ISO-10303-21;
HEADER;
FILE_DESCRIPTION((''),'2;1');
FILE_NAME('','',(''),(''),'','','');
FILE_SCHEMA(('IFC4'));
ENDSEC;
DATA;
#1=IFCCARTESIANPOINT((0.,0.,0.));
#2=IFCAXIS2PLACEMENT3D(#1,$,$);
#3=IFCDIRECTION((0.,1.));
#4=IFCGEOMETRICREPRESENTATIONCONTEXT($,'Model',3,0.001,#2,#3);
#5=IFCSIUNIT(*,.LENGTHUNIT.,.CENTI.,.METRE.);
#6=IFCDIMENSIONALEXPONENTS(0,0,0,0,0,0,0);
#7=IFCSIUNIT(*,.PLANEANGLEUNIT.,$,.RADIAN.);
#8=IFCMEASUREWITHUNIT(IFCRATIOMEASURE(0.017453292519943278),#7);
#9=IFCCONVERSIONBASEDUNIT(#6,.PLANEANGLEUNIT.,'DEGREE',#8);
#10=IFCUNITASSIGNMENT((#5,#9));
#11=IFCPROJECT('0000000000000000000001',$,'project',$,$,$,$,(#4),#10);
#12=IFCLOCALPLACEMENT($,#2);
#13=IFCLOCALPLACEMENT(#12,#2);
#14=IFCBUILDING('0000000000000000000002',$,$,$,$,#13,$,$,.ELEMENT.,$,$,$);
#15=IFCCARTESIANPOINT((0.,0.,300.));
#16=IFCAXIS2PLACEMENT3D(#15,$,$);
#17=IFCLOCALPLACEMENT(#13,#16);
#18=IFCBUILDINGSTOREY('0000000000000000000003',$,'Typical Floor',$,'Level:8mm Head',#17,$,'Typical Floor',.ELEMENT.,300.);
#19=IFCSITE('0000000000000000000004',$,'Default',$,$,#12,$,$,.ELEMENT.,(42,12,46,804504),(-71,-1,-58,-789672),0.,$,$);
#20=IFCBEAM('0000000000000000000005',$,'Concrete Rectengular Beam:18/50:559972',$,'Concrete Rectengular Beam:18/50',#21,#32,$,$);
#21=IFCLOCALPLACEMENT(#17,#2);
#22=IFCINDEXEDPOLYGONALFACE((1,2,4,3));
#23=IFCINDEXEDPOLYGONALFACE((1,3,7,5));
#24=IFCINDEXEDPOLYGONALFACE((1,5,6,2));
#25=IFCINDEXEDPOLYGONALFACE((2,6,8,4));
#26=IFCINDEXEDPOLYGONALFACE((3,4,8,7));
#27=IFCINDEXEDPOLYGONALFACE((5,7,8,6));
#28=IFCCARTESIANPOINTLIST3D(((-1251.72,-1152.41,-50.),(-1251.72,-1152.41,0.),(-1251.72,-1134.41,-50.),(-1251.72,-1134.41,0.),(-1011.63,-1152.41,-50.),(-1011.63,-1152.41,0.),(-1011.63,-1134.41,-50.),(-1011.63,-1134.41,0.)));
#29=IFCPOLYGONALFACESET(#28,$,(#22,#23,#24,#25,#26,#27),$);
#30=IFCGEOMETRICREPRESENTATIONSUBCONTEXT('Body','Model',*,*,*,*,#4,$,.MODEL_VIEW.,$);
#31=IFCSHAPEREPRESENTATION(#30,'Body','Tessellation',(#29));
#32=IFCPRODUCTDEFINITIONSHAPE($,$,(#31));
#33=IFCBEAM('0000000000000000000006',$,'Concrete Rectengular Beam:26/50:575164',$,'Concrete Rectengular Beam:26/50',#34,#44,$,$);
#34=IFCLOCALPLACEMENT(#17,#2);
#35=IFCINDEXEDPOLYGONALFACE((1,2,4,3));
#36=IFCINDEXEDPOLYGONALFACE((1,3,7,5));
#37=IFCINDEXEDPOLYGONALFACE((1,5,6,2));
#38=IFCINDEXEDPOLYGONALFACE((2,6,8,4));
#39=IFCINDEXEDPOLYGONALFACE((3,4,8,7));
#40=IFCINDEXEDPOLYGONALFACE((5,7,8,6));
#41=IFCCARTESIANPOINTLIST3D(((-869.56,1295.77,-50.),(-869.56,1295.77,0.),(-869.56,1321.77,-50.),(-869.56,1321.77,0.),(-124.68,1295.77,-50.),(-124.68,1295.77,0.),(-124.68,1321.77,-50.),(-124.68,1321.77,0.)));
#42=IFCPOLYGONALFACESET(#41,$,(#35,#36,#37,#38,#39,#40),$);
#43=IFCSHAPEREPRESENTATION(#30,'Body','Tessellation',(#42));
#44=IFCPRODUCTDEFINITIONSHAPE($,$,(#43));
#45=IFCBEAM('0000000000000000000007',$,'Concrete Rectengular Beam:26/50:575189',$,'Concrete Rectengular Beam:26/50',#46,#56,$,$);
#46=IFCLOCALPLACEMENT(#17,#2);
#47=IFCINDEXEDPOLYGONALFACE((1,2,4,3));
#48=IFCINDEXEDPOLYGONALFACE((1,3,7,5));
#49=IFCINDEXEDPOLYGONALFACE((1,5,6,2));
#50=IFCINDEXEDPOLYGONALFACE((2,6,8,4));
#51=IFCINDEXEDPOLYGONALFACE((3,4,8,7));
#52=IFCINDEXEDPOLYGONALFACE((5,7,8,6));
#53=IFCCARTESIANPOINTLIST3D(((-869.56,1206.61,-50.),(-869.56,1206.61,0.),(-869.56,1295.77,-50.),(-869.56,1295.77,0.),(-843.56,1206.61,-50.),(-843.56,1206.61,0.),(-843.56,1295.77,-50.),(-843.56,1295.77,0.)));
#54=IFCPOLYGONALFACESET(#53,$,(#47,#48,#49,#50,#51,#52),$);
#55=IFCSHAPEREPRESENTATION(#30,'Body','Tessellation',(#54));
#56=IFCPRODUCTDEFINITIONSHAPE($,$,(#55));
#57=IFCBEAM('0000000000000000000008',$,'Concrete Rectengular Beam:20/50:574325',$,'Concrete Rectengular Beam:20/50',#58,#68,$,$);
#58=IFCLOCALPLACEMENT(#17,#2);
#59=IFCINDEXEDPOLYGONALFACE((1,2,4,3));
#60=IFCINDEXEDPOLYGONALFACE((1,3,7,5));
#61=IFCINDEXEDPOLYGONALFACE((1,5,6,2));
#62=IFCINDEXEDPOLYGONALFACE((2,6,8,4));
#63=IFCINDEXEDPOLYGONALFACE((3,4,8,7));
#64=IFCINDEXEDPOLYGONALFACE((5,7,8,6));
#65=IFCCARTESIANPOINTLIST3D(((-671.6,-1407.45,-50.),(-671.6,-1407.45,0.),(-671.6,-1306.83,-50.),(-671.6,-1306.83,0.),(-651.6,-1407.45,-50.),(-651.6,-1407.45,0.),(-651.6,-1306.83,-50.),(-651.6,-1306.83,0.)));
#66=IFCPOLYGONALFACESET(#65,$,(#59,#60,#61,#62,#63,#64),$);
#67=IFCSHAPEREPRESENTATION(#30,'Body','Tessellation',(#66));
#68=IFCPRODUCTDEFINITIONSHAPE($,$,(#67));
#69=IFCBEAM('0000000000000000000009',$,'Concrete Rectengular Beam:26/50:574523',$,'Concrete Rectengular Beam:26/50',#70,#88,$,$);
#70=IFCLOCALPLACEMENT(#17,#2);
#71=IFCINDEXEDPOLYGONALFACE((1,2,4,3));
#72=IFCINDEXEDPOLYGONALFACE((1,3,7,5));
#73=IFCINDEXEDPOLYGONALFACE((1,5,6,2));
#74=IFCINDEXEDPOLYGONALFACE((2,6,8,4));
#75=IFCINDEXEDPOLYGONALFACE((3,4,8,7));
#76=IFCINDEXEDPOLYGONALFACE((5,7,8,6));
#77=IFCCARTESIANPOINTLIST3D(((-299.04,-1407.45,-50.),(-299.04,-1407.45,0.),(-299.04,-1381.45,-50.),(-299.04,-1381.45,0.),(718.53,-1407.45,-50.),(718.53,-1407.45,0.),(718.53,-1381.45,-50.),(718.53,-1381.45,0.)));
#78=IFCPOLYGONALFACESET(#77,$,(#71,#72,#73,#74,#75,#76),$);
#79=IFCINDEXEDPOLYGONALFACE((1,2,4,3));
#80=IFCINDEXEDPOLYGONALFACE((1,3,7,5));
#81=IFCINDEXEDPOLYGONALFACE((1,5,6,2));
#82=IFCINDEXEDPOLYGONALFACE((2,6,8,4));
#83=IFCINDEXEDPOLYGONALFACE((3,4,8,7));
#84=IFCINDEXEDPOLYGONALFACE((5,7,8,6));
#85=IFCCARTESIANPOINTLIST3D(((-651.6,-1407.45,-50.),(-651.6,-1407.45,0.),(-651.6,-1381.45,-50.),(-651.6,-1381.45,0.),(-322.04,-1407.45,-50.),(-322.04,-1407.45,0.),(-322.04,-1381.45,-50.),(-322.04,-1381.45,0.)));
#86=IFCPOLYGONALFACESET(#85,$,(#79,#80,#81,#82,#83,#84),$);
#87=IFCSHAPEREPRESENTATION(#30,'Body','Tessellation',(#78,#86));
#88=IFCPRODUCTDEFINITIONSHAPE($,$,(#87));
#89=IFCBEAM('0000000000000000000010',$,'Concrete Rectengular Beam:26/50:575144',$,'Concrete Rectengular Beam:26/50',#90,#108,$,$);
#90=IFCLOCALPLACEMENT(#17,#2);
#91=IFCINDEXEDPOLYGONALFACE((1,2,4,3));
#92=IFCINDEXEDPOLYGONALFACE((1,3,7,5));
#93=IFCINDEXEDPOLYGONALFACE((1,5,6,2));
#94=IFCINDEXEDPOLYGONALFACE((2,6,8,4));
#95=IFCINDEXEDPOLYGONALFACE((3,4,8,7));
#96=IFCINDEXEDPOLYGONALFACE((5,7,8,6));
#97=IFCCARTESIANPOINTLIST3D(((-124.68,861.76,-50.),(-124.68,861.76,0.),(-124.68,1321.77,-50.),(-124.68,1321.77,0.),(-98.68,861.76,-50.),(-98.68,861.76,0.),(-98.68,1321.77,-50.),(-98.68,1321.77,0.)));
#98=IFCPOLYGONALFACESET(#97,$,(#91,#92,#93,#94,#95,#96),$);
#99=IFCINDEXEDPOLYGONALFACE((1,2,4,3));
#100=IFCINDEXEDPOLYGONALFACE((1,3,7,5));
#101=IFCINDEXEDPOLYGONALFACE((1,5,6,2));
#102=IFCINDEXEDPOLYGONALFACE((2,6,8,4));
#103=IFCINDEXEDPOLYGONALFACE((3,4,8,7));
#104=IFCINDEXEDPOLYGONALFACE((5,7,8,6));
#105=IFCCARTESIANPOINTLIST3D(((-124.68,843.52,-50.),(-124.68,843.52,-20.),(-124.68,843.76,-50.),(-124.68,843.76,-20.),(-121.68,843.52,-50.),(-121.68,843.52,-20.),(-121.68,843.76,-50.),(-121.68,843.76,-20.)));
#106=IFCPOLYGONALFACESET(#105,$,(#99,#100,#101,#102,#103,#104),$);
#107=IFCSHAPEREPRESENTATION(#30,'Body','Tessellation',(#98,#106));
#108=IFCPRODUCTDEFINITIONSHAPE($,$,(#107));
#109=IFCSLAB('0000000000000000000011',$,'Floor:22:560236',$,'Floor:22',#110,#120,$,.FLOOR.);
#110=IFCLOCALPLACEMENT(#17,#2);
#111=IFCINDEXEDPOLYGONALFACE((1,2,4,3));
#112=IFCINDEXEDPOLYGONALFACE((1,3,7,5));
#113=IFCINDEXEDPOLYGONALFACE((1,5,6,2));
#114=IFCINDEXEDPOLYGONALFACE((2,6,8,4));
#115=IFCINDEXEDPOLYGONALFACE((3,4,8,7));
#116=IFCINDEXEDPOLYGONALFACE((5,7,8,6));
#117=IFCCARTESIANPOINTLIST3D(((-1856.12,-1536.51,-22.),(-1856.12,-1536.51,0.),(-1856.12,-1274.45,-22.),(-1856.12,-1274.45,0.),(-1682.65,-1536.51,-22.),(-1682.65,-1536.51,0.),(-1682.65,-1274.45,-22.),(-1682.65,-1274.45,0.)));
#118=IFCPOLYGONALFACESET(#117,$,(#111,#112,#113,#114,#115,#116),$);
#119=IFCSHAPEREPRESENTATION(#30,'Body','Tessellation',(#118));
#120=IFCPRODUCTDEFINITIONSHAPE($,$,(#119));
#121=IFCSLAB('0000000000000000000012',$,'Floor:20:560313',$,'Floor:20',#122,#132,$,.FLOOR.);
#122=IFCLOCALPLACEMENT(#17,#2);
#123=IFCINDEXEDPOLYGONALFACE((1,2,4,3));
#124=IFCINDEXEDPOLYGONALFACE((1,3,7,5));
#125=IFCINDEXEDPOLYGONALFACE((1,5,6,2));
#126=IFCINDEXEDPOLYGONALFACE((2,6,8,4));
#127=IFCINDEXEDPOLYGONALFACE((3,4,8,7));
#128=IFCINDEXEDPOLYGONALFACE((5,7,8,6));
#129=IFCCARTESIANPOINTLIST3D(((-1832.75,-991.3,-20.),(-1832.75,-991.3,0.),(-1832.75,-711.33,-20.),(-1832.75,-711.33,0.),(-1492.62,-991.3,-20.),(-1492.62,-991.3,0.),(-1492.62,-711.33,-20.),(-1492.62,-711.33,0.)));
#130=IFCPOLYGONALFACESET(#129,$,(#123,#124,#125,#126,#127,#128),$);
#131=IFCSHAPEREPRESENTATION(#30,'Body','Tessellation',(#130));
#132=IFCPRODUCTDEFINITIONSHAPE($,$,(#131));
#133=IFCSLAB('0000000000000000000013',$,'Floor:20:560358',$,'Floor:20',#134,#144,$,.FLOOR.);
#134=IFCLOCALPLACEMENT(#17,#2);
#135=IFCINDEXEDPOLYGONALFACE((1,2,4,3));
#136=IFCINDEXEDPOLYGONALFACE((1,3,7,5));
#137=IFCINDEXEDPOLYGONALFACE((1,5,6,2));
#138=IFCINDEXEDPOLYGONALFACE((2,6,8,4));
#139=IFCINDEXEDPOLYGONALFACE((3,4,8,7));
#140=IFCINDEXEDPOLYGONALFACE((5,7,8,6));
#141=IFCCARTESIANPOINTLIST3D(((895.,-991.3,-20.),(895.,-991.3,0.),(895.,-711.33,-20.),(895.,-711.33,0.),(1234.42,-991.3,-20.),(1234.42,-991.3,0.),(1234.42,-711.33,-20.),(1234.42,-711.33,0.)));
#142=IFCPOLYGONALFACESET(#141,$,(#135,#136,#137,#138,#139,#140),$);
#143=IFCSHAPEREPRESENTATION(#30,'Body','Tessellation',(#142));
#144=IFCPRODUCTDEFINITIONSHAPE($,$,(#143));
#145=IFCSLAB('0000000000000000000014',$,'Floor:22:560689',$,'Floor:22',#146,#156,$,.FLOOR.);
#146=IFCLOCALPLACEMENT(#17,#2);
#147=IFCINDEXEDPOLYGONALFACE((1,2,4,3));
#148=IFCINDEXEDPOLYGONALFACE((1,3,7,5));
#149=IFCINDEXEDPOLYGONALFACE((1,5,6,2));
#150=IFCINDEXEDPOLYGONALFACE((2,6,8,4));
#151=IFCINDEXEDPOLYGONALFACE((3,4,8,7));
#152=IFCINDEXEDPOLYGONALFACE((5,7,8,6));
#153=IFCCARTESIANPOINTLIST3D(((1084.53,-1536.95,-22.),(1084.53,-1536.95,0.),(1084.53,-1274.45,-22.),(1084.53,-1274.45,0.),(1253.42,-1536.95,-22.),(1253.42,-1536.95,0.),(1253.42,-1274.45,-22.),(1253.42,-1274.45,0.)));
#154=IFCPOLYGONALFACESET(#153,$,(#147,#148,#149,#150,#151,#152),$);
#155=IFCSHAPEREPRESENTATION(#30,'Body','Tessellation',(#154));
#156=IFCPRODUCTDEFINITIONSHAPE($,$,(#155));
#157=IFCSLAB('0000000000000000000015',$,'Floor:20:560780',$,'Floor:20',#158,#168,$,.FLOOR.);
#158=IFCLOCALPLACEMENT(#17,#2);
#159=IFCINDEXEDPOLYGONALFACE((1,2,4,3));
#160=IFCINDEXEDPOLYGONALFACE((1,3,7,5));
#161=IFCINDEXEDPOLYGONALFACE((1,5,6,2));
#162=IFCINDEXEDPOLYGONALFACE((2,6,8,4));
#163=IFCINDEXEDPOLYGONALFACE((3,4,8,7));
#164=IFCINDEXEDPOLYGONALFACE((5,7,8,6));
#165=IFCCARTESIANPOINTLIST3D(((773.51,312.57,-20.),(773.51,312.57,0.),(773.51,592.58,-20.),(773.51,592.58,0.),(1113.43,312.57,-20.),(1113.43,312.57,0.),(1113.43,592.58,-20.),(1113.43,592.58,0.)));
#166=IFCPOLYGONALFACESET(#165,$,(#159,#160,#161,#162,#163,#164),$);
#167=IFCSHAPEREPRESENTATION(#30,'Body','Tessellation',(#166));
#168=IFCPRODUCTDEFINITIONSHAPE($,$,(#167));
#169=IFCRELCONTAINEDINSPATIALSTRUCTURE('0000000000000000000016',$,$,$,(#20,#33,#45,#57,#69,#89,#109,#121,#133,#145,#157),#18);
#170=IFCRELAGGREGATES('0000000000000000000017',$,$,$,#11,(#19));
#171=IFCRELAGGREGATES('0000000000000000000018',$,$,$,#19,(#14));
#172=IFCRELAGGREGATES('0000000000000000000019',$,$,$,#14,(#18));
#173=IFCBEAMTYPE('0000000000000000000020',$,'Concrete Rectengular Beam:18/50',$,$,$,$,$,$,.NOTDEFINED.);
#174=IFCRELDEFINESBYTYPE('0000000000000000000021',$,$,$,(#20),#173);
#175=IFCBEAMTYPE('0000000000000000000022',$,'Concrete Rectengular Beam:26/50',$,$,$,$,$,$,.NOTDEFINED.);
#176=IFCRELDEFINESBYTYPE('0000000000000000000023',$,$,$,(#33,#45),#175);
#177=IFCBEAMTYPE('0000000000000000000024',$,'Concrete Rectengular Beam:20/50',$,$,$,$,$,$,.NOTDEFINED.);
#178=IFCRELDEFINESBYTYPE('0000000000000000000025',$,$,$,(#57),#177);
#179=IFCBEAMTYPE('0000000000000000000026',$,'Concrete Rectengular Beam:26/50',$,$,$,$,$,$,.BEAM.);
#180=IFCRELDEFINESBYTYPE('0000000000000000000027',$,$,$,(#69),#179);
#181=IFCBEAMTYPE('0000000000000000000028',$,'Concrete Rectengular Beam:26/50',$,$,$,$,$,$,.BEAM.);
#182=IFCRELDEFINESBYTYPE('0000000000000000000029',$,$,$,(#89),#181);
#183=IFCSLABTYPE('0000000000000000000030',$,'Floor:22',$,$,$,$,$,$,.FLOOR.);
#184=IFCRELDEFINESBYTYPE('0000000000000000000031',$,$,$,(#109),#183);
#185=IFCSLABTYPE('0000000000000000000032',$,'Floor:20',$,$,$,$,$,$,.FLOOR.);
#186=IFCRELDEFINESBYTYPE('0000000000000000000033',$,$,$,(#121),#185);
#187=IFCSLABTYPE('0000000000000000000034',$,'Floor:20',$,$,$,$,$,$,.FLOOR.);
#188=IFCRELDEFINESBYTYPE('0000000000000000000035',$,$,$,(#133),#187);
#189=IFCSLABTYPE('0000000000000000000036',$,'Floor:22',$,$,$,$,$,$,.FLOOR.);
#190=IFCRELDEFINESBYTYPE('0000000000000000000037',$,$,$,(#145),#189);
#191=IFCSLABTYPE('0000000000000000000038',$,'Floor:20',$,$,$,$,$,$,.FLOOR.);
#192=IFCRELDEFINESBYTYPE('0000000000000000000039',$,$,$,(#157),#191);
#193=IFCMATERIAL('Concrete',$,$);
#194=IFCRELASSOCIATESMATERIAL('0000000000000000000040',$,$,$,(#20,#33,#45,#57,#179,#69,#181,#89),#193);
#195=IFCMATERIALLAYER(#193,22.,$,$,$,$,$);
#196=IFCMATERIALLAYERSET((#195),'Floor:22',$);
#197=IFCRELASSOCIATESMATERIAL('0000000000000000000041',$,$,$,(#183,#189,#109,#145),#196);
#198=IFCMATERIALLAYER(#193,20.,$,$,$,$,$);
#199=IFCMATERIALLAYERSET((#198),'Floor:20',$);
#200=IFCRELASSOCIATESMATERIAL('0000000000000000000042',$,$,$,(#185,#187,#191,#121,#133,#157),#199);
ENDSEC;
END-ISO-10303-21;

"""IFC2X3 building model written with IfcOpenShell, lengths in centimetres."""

from ifc_helpers import new_model, entity, si_unit, converted_unit, direction, frame, frame_2d, origin, origin_2d_with_axis, place, context, subcontext, project, spatial, rectangle, extrude, source, transform, mapped, material, layer, layer_set, layer_usage, type_object, type_shapes, element, save


model = new_model("IFC2X3")

# Units and contexts
model_context = context("Model", 3, precision=0.001, world=origin(), true_north=direction((0.0, 1.0)))
body_context = subcontext(model_context, "Body", "Model", "MODEL_VIEW")
ifc_project = project(units=[si_unit("LENGTHUNIT", "METRE", prefix="CENTI"), converted_unit("PLANEANGLEUNIT", "DEGREE", entity("IfcRatioMeasure", 0.017453292519943278), si_unit("PLANEANGLEUNIT", "RADIAN"), dimensions=[0, 0, 0, 0, 0, 0, 0])], contexts=[model_context])

# Site, building, storey
site_placement = place(None, origin())
site = spatial("IfcSite", under=ifc_project, at=site_placement, Name="Default", CompositionType="ELEMENT", RefLatitude=(42, 12, 46, 804504), RefLongitude=(-71, -1, -58, -789672), RefElevation=0.0)
building_placement = place(site_placement, origin())
building = spatial("IfcBuilding", under=site, at=building_placement, CompositionType="ELEMENT")
storey_placement = place(building_placement, frame((0.0, 0.0, 300.0)))
storey = spatial("IfcBuildingStorey", under=building, at=storey_placement, Name="Typical Floor", ObjectType="Level:8mm Head", LongName="Typical Floor", CompositionType="ELEMENT", Elevation=300.0)

# Beams
ifc_material = material(Name="Concrete")
beam_type_1 = type_object("IfcBeamType", Name="Concrete Rectengular Beam:18/50", PredefinedType="NOTDEFINED")
beam_1_placement = place(storey_placement, frame((-1251.72, -1143.41, 0.0)))
element("IfcBeam", 1, at=beam_1_placement, inside=storey, type_object=beam_type_1, material=ifc_material, Name="Concrete Rectengular Beam:18/50:559972", ObjectType="Concrete Rectengular Beam:18/50", context=body_context, shape_type="SweptSolid", body=[
    extrude(rectangle(XDim=50.0, YDim=18.0, at=frame_2d((0.0, 0.0), x_axis=(1.0, 0.0))), frame((0.0, 0.0, -25.0), z_axis=(1.0, 0.0, 0.0), x_axis=(0.0, 0.0, -1.0)), (0.0, 0.0, 1.0), 240.09),
])
beam_type_2 = type_object("IfcBeamType", Name="Concrete Rectengular Beam:26/50", PredefinedType="NOTDEFINED")
beam_2_placement = place(storey_placement, frame((-111.68, 1308.77, 0.0), z_axis=(0.0, 0.0, 1.0), x_axis=(-1.0, 0.0, 0.0)))
element("IfcBeam", 2, at=beam_2_placement, inside=storey, type_object=beam_type_2, material=ifc_material, Name="Concrete Rectengular Beam:26/50:575164", ObjectType="Concrete Rectengular Beam:26/50", context=body_context, shape_type="SweptSolid", body=[
    extrude(rectangle(XDim=50.0, YDim=26.0, at=frame_2d((0.0, 0.0), x_axis=(1.0, 0.0))), frame((13.0, 0.0, -25.0), z_axis=(1.0, 0.0, 0.0), x_axis=(0.0, 0.0, -1.0)), (0.0, 0.0, 1.0), 744.88),
])
beam_3_placement = place(storey_placement, frame((-856.56, 1308.77, 0.0), z_axis=(0.0, 0.0, 1.0), x_axis=(0.0, -1.0, 0.0)))
element("IfcBeam", 3, at=beam_3_placement, inside=storey, type_object=beam_type_2, material=ifc_material, Name="Concrete Rectengular Beam:26/50:575189", ObjectType="Concrete Rectengular Beam:26/50", context=body_context, shape_type="SweptSolid", body=[
    extrude(rectangle(XDim=50.0, YDim=26.0, at=frame_2d((0.0, 0.0), x_axis=(1.0, 0.0))), frame((13.0, 0.0, -25.0), z_axis=(1.0, 0.0, 0.0), x_axis=(0.0, 0.0, -1.0)), (0.0, 0.0, 1.0), 89.16),
])
beam_type_3 = type_object("IfcBeamType", Name="Concrete Rectengular Beam:20/50", PredefinedType="NOTDEFINED")
beam_4_placement = place(storey_placement, frame((-661.6, -1306.83, 0.0), z_axis=(0.0, 0.0, 1.0), x_axis=(0.0, -1.0, 0.0)))
element("IfcBeam", 4, at=beam_4_placement, inside=storey, type_object=beam_type_3, material=ifc_material, Name="Concrete Rectengular Beam:20/50:574325", ObjectType="Concrete Rectengular Beam:20/50", context=body_context, shape_type="SweptSolid", body=[
    extrude(rectangle(XDim=50.0, YDim=20.0, at=frame_2d((0.0, 0.0), x_axis=(1.0, 0.0))), frame((0.0, 0.0, -25.0), z_axis=(1.0, 0.0, 0.0), x_axis=(0.0, 0.0, -1.0)), (0.0, 0.0, 1.0), 100.62),
])
beam_type_4 = type_object("IfcBeamType", Name="Concrete Rectengular Beam:26/50", PredefinedType="BEAM", material=ifc_material)
shared_shape_1 = source(origin(), body_context, "Body", "SweptSolid", [
    extrude(rectangle(XDim=50.0, YDim=26.0, at=frame_2d((0.0, 0.0), x_axis=(1.0, 0.0))), frame((-299.04, -1394.45, 275.0), z_axis=(1.0, 0.0, 0.0), x_axis=(0.0, 0.0, -1.0)), (0.0, 0.0, 1.0), 1017.58),
    extrude(rectangle(XDim=50.0, YDim=26.0, at=frame_2d((0.0, 0.0), x_axis=(1.0, 0.0))), frame((-651.6, -1394.45, 275.0), z_axis=(1.0, 0.0, 0.0), x_axis=(0.0, 0.0, -1.0)), (0.0, 0.0, 1.0), 329.56),
])
type_shapes(beam_type_4, [shared_shape_1])
beam_5_placement = place(storey_placement, frame((0.0, 0.0, -300.0)))
element("IfcBeam", 5, at=beam_5_placement, inside=storey, type_object=beam_type_4, material=ifc_material, Name="Concrete Rectengular Beam:26/50:574523", ObjectType="Concrete Rectengular Beam:26/50", context=body_context, shape_type="MappedRepresentation", body=[
    mapped(shared_shape_1, transform((0.0, 0.0, 0.0), scale=1.0)),
])
beam_type_5 = type_object("IfcBeamType", Name="Concrete Rectengular Beam:26/50", PredefinedType="BEAM", material=ifc_material)
shared_shape_2 = source(origin(), body_context, "Body", "SweptSolid", [
    extrude(rectangle(XDim=50.0, YDim=26.0, at=frame_2d((0.0, 0.0), x_axis=(0.0, 1.0))), frame((-111.68, 861.76, 275.0), z_axis=(0.0, 1.0, 0.0), x_axis=(-1.0, 0.0, 0.0)), (0.0, 0.0, 1.0), 460.01),
    extrude(rectangle(XDim=30.0, YDim=3.0, at=frame_2d((0.0, 0.0), x_axis=(0.0, 1.0))), frame((-123.18, 843.52, 265.0), z_axis=(0.0, 1.0, 0.0), x_axis=(-1.0, 0.0, 0.0)), (0.0, 0.0, 1.0), 0.24),
])
type_shapes(beam_type_5, [shared_shape_2])
beam_6_placement = place(storey_placement, frame((0.0, 0.0, -300.0)))
element("IfcBeam", 6, at=beam_6_placement, inside=storey, type_object=beam_type_5, material=ifc_material, Name="Concrete Rectengular Beam:26/50:575144", ObjectType="Concrete Rectengular Beam:26/50", context=body_context, shape_type="MappedRepresentation", body=[
    mapped(shared_shape_2, transform((0.0, 0.0, 0.0), scale=1.0)),
])

# Slabs
ifc_layer_1 = layer(ifc_material, 22.0)
ifc_layer_set_1 = layer_set([ifc_layer_1], Name="Floor:22")
ifc_layer_usage_1 = layer_usage(ifc_layer_set_1, "AXIS3", "POSITIVE", 0.0)
slab_type_1 = type_object("IfcSlabType", Name="Floor:22", PredefinedType="FLOOR", material=ifc_layer_set_1)
slab_1_placement = place(storey_placement, origin())
element("IfcSlab", 7, at=slab_1_placement, inside=storey, type_object=slab_type_1, material=ifc_layer_usage_1, Name="Floor:22:560236", ObjectType="Floor:22", PredefinedType="FLOOR", context=body_context, shape_type="SweptSolid", body=[
    extrude(rectangle(XDim=262.05, YDim=173.47, at=frame_2d((0.0, 0.0), x_axis=(1.0, 0.0))), frame((-1769.39, -1405.48, 0.0), z_axis=(0.0, 0.0, -1.0), x_axis=(0.0, 1.0, 0.0)), (0.0, 0.0, 1.0), 22.0),
])
ifc_layer_2 = layer(ifc_material, 20.0)
ifc_layer_set_2 = layer_set([ifc_layer_2], Name="Floor:20")
ifc_layer_usage_2 = layer_usage(ifc_layer_set_2, "AXIS3", "POSITIVE", 0.0)
slab_type_2 = type_object("IfcSlabType", Name="Floor:20", PredefinedType="FLOOR", material=ifc_layer_set_2)
slab_2_placement = place(storey_placement, origin())
element("IfcSlab", 8, at=slab_2_placement, inside=storey, type_object=slab_type_2, material=ifc_layer_usage_2, Name="Floor:20:560313", ObjectType="Floor:20", PredefinedType="FLOOR", context=body_context, shape_type="SweptSolid", body=[
    extrude(rectangle(XDim=279.98, YDim=340.13, at=frame_2d((0.0, 0.0), x_axis=(1.0, 0.0))), frame((-1662.69, -851.32, 0.0), z_axis=(0.0, 0.0, -1.0), x_axis=(0.0, 1.0, 0.0)), (0.0, 0.0, 1.0), 20.0),
])
ifc_layer_usage_3 = layer_usage(ifc_layer_set_2, "AXIS3", "POSITIVE", 0.0)
slab_type_3 = type_object("IfcSlabType", Name="Floor:20", PredefinedType="FLOOR", material=ifc_layer_set_2)
slab_3_placement = place(storey_placement, origin())
element("IfcSlab", 9, at=slab_3_placement, inside=storey, type_object=slab_type_3, material=ifc_layer_usage_3, Name="Floor:20:560358", ObjectType="Floor:20", PredefinedType="FLOOR", context=body_context, shape_type="SweptSolid", body=[
    extrude(rectangle(XDim=279.98, YDim=339.42, at=origin_2d_with_axis()), frame((1064.71, -851.32, 0.0), z_axis=(0.0, 0.0, -1.0), x_axis=(0.0, 1.0, 0.0)), (0.0, 0.0, 1.0), 20.0),
])
ifc_layer_usage_4 = layer_usage(ifc_layer_set_1, "AXIS3", "POSITIVE", 0.0)
slab_type_4 = type_object("IfcSlabType", Name="Floor:22", PredefinedType="FLOOR", material=ifc_layer_set_1)
slab_4_placement = place(storey_placement, origin())
element("IfcSlab", 10, at=slab_4_placement, inside=storey, type_object=slab_type_4, material=ifc_layer_usage_4, Name="Floor:22:560689", ObjectType="Floor:22", PredefinedType="FLOOR", context=body_context, shape_type="SweptSolid", body=[
    extrude(rectangle(XDim=262.5, YDim=168.89, at=frame_2d((0.0, 0.0), x_axis=(1.0, 0.0))), frame((1168.98, -1405.7, 0.0), z_axis=(0.0, 0.0, -1.0), x_axis=(0.0, 1.0, 0.0)), (0.0, 0.0, 1.0), 22.0),
])
ifc_layer_usage_5 = layer_usage(ifc_layer_set_2, "AXIS3", "POSITIVE", 0.0)
slab_type_5 = type_object("IfcSlabType", Name="Floor:20", PredefinedType="FLOOR", material=ifc_layer_set_2)
slab_5_placement = place(storey_placement, origin())
element("IfcSlab", 11, at=slab_5_placement, inside=storey, type_object=slab_type_5, material=ifc_layer_usage_5, Name="Floor:20:560780", ObjectType="Floor:20", PredefinedType="FLOOR", context=body_context, shape_type="SweptSolid", body=[
    extrude(rectangle(XDim=280.01, YDim=339.91, at=frame_2d((0.0, 0.0), x_axis=(1.0, 0.0))), frame((943.47, 452.58, 0.0), z_axis=(0.0, 0.0, -1.0), x_axis=(0.0, 1.0, 0.0)), (0.0, 0.0, 1.0), 20.0),
])

save(model, "model.ifc")
